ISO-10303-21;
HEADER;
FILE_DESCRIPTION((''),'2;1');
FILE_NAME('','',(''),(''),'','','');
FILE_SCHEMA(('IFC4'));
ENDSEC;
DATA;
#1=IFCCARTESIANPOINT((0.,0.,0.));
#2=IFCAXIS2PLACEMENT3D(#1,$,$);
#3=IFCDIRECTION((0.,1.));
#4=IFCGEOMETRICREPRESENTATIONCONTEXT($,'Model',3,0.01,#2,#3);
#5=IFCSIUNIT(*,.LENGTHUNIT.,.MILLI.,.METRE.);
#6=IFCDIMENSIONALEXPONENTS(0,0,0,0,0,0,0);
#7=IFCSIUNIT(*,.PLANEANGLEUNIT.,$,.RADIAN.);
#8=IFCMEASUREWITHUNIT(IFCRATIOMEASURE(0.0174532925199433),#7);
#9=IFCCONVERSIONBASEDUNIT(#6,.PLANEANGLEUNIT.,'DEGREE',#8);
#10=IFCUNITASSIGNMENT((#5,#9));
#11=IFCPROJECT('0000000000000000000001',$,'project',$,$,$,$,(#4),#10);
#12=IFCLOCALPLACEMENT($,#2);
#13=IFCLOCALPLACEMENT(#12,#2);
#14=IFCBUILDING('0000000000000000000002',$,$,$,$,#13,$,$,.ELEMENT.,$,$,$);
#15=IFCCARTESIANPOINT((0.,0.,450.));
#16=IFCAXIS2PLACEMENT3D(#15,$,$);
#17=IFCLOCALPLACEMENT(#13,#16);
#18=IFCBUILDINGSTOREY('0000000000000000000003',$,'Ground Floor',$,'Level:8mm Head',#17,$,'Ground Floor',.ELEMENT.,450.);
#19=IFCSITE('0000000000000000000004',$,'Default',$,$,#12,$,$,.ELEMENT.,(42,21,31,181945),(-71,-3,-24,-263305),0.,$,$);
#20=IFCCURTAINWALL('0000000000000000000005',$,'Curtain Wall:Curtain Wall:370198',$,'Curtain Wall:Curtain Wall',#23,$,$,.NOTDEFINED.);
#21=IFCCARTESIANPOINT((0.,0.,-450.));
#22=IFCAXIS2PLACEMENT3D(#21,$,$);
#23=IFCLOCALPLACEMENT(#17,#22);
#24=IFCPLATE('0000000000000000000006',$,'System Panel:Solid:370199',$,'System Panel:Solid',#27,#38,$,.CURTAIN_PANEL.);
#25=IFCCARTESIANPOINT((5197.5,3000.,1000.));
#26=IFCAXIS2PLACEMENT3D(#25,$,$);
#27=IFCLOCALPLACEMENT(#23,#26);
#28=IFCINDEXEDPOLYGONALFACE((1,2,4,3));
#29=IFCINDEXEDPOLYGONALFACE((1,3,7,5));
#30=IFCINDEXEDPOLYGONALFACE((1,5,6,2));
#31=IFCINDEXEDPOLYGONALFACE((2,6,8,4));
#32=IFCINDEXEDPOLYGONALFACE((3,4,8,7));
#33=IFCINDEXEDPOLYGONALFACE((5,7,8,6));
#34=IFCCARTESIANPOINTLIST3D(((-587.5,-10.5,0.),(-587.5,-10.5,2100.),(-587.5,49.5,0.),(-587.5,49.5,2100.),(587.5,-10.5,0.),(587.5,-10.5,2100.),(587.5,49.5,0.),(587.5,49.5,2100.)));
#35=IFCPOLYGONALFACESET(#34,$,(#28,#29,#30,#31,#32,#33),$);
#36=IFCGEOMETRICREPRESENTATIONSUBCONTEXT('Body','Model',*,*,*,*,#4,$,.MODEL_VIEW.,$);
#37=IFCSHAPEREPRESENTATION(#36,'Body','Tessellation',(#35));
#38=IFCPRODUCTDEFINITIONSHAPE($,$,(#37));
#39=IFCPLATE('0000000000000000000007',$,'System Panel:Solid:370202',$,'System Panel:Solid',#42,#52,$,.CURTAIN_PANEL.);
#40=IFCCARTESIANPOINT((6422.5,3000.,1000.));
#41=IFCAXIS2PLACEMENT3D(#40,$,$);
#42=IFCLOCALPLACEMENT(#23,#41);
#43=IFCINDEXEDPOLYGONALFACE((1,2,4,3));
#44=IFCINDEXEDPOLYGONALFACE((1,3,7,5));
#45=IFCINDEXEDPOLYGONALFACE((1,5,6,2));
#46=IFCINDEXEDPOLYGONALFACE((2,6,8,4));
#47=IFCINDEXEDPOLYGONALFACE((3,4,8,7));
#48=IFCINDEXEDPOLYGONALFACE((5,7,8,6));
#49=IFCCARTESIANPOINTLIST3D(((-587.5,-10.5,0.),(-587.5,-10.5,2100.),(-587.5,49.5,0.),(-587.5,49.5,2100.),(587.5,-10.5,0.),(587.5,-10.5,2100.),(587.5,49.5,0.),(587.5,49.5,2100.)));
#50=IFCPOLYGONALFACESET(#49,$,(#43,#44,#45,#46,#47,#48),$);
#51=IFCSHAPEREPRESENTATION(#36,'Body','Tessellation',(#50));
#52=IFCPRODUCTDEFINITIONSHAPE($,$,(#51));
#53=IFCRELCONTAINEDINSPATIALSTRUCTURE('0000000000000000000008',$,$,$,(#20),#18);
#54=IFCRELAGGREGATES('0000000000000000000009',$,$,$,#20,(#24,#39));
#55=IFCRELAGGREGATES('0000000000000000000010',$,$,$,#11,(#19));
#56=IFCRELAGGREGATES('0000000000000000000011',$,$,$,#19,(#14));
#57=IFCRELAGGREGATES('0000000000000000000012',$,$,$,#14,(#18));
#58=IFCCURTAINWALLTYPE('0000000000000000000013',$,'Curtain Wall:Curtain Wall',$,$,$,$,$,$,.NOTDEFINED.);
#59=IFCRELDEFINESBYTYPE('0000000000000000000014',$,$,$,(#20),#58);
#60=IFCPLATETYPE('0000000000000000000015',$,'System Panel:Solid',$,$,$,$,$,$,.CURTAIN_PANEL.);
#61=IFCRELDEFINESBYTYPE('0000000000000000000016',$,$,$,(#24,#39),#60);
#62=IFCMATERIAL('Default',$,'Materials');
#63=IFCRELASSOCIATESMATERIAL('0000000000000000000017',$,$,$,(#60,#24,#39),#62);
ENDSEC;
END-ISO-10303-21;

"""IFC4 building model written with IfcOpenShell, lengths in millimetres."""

from ifc_helpers import new_model, entity, si_unit, converted_unit, direction, frame, origin, origin_2d_with_axis, place, context, subcontext, project, spatial, rectangle, extrude, shape, source, transform, mapped, material, type_object, type_shapes, element, aggregate, save


model = new_model("IFC4")

# Units and contexts
model_context = context("Model", 3, precision=0.01, world=origin(), true_north=direction((0.0, 1.0)))
body_context = subcontext(model_context, "Body", "Model", "MODEL_VIEW")
footprint_context = subcontext(model_context, "FootPrint", "Model", "MODEL_VIEW")
ifc_project = project(units=[si_unit("LENGTHUNIT", "METRE", prefix="MILLI"), converted_unit("PLANEANGLEUNIT", "DEGREE", entity("IfcRatioMeasure", 0.0174532925199433), si_unit("PLANEANGLEUNIT", "RADIAN"), dimensions=[0, 0, 0, 0, 0, 0, 0])], contexts=[model_context])

# Site, building, storey
site_placement = place(None, origin())
site = spatial("IfcSite", under=ifc_project, at=site_placement, Name="Default", CompositionType="ELEMENT", RefLatitude=(42, 21, 31, 181945), RefLongitude=(-71, -3, -24, -263305), RefElevation=0.0)
building_placement = place(site_placement, origin())
building = spatial("IfcBuilding", under=site, at=building_placement, CompositionType="ELEMENT")
storey_placement = place(building_placement, frame((0.0, 0.0, 450.0)))
storey = spatial("IfcBuildingStorey", under=building, at=storey_placement, Name="Ground Floor", ObjectType="Level:8mm Head", LongName="Ground Floor", CompositionType="ELEMENT", Elevation=450.0)

# Curtain wall
curtain_wall_type = type_object("IfcCurtainWallType", Name="Curtain Wall:Curtain Wall", PredefinedType="NOTDEFINED")
curtain_wall_placement = place(storey_placement, frame((0.0, 0.0, -450.0)))
curtain_wall = element("IfcCurtainWall", 1, at=curtain_wall_placement, inside=storey, type_object=curtain_wall_type, Name="Curtain Wall:Curtain Wall:370198", ObjectType="Curtain Wall:Curtain Wall", PredefinedType="NOTDEFINED")

# Plates
ifc_material_1 = material(Name="Default", Category="Materials")
plate_type = type_object("IfcPlateType", Name="System Panel:Solid", PredefinedType="CURTAIN_PANEL", material=ifc_material_1)
shared_shape_1 = source(origin(), body_context, "Body", "SweptSolid", [
    extrude(rectangle(XDim=60.0, YDim=1175.0, at=origin_2d_with_axis()), frame((0.0, 19.5, 0.0), z_axis=(0.0, 0.0, 1.0), x_axis=(0.0, 1.0, 0.0)), (0.0, 0.0, 1.0), 2100.0),
])
cartesian_point = entity("IfcCartesianPoint", [587.5, -10.5])
shared_shape_2 = source(origin(), footprint_context, "FootPrint", "Curve2D", [
    entity("IfcPolyline", [cartesian_point, entity("IfcCartesianPoint", [587.5, 49.5]), entity("IfcCartesianPoint", [-587.5, 49.5]), entity("IfcCartesianPoint", [-587.5, -10.5]), cartesian_point]),
])
type_shapes(plate_type, [shared_shape_1, shared_shape_2])
plate_1_placement = place(curtain_wall_placement, frame((5197.5, 3000.0, 1000.0)))
plate_1 = element("IfcPlate", 2, at=plate_1_placement, type_object=plate_type, material=ifc_material_1, Name="System Panel:Solid:370199", ObjectType="System Panel:Solid", PredefinedType="CURTAIN_PANEL", shapes=[
    shape(body_context, "Body", "MappedRepresentation", [mapped(shared_shape_1, transform((0.0, 0.0, 0.0), scale=1.0))]),
    shape(body_context, "Body", "MappedRepresentation", [mapped(shared_shape_2, transform((0.0, 0.0, 0.0), scale=1.0))]),
])
plate_2_placement = place(curtain_wall_placement, frame((6422.5, 3000.0, 1000.0)))
plate_2 = element("IfcPlate", 3, at=plate_2_placement, type_object=plate_type, material=ifc_material_1, Name="System Panel:Solid:370202", ObjectType="System Panel:Solid", PredefinedType="CURTAIN_PANEL", shapes=[
    shape(body_context, "Body", "MappedRepresentation", [mapped(shared_shape_1, transform((0.0, 0.0, 0.0), scale=1.0))]),
    shape(body_context, "Body", "MappedRepresentation", [mapped(shared_shape_2, transform((0.0, 0.0, 0.0), scale=1.0))]),
])
aggregate(curtain_wall, [plate_1, plate_2])

save(model, "model.ifc")
